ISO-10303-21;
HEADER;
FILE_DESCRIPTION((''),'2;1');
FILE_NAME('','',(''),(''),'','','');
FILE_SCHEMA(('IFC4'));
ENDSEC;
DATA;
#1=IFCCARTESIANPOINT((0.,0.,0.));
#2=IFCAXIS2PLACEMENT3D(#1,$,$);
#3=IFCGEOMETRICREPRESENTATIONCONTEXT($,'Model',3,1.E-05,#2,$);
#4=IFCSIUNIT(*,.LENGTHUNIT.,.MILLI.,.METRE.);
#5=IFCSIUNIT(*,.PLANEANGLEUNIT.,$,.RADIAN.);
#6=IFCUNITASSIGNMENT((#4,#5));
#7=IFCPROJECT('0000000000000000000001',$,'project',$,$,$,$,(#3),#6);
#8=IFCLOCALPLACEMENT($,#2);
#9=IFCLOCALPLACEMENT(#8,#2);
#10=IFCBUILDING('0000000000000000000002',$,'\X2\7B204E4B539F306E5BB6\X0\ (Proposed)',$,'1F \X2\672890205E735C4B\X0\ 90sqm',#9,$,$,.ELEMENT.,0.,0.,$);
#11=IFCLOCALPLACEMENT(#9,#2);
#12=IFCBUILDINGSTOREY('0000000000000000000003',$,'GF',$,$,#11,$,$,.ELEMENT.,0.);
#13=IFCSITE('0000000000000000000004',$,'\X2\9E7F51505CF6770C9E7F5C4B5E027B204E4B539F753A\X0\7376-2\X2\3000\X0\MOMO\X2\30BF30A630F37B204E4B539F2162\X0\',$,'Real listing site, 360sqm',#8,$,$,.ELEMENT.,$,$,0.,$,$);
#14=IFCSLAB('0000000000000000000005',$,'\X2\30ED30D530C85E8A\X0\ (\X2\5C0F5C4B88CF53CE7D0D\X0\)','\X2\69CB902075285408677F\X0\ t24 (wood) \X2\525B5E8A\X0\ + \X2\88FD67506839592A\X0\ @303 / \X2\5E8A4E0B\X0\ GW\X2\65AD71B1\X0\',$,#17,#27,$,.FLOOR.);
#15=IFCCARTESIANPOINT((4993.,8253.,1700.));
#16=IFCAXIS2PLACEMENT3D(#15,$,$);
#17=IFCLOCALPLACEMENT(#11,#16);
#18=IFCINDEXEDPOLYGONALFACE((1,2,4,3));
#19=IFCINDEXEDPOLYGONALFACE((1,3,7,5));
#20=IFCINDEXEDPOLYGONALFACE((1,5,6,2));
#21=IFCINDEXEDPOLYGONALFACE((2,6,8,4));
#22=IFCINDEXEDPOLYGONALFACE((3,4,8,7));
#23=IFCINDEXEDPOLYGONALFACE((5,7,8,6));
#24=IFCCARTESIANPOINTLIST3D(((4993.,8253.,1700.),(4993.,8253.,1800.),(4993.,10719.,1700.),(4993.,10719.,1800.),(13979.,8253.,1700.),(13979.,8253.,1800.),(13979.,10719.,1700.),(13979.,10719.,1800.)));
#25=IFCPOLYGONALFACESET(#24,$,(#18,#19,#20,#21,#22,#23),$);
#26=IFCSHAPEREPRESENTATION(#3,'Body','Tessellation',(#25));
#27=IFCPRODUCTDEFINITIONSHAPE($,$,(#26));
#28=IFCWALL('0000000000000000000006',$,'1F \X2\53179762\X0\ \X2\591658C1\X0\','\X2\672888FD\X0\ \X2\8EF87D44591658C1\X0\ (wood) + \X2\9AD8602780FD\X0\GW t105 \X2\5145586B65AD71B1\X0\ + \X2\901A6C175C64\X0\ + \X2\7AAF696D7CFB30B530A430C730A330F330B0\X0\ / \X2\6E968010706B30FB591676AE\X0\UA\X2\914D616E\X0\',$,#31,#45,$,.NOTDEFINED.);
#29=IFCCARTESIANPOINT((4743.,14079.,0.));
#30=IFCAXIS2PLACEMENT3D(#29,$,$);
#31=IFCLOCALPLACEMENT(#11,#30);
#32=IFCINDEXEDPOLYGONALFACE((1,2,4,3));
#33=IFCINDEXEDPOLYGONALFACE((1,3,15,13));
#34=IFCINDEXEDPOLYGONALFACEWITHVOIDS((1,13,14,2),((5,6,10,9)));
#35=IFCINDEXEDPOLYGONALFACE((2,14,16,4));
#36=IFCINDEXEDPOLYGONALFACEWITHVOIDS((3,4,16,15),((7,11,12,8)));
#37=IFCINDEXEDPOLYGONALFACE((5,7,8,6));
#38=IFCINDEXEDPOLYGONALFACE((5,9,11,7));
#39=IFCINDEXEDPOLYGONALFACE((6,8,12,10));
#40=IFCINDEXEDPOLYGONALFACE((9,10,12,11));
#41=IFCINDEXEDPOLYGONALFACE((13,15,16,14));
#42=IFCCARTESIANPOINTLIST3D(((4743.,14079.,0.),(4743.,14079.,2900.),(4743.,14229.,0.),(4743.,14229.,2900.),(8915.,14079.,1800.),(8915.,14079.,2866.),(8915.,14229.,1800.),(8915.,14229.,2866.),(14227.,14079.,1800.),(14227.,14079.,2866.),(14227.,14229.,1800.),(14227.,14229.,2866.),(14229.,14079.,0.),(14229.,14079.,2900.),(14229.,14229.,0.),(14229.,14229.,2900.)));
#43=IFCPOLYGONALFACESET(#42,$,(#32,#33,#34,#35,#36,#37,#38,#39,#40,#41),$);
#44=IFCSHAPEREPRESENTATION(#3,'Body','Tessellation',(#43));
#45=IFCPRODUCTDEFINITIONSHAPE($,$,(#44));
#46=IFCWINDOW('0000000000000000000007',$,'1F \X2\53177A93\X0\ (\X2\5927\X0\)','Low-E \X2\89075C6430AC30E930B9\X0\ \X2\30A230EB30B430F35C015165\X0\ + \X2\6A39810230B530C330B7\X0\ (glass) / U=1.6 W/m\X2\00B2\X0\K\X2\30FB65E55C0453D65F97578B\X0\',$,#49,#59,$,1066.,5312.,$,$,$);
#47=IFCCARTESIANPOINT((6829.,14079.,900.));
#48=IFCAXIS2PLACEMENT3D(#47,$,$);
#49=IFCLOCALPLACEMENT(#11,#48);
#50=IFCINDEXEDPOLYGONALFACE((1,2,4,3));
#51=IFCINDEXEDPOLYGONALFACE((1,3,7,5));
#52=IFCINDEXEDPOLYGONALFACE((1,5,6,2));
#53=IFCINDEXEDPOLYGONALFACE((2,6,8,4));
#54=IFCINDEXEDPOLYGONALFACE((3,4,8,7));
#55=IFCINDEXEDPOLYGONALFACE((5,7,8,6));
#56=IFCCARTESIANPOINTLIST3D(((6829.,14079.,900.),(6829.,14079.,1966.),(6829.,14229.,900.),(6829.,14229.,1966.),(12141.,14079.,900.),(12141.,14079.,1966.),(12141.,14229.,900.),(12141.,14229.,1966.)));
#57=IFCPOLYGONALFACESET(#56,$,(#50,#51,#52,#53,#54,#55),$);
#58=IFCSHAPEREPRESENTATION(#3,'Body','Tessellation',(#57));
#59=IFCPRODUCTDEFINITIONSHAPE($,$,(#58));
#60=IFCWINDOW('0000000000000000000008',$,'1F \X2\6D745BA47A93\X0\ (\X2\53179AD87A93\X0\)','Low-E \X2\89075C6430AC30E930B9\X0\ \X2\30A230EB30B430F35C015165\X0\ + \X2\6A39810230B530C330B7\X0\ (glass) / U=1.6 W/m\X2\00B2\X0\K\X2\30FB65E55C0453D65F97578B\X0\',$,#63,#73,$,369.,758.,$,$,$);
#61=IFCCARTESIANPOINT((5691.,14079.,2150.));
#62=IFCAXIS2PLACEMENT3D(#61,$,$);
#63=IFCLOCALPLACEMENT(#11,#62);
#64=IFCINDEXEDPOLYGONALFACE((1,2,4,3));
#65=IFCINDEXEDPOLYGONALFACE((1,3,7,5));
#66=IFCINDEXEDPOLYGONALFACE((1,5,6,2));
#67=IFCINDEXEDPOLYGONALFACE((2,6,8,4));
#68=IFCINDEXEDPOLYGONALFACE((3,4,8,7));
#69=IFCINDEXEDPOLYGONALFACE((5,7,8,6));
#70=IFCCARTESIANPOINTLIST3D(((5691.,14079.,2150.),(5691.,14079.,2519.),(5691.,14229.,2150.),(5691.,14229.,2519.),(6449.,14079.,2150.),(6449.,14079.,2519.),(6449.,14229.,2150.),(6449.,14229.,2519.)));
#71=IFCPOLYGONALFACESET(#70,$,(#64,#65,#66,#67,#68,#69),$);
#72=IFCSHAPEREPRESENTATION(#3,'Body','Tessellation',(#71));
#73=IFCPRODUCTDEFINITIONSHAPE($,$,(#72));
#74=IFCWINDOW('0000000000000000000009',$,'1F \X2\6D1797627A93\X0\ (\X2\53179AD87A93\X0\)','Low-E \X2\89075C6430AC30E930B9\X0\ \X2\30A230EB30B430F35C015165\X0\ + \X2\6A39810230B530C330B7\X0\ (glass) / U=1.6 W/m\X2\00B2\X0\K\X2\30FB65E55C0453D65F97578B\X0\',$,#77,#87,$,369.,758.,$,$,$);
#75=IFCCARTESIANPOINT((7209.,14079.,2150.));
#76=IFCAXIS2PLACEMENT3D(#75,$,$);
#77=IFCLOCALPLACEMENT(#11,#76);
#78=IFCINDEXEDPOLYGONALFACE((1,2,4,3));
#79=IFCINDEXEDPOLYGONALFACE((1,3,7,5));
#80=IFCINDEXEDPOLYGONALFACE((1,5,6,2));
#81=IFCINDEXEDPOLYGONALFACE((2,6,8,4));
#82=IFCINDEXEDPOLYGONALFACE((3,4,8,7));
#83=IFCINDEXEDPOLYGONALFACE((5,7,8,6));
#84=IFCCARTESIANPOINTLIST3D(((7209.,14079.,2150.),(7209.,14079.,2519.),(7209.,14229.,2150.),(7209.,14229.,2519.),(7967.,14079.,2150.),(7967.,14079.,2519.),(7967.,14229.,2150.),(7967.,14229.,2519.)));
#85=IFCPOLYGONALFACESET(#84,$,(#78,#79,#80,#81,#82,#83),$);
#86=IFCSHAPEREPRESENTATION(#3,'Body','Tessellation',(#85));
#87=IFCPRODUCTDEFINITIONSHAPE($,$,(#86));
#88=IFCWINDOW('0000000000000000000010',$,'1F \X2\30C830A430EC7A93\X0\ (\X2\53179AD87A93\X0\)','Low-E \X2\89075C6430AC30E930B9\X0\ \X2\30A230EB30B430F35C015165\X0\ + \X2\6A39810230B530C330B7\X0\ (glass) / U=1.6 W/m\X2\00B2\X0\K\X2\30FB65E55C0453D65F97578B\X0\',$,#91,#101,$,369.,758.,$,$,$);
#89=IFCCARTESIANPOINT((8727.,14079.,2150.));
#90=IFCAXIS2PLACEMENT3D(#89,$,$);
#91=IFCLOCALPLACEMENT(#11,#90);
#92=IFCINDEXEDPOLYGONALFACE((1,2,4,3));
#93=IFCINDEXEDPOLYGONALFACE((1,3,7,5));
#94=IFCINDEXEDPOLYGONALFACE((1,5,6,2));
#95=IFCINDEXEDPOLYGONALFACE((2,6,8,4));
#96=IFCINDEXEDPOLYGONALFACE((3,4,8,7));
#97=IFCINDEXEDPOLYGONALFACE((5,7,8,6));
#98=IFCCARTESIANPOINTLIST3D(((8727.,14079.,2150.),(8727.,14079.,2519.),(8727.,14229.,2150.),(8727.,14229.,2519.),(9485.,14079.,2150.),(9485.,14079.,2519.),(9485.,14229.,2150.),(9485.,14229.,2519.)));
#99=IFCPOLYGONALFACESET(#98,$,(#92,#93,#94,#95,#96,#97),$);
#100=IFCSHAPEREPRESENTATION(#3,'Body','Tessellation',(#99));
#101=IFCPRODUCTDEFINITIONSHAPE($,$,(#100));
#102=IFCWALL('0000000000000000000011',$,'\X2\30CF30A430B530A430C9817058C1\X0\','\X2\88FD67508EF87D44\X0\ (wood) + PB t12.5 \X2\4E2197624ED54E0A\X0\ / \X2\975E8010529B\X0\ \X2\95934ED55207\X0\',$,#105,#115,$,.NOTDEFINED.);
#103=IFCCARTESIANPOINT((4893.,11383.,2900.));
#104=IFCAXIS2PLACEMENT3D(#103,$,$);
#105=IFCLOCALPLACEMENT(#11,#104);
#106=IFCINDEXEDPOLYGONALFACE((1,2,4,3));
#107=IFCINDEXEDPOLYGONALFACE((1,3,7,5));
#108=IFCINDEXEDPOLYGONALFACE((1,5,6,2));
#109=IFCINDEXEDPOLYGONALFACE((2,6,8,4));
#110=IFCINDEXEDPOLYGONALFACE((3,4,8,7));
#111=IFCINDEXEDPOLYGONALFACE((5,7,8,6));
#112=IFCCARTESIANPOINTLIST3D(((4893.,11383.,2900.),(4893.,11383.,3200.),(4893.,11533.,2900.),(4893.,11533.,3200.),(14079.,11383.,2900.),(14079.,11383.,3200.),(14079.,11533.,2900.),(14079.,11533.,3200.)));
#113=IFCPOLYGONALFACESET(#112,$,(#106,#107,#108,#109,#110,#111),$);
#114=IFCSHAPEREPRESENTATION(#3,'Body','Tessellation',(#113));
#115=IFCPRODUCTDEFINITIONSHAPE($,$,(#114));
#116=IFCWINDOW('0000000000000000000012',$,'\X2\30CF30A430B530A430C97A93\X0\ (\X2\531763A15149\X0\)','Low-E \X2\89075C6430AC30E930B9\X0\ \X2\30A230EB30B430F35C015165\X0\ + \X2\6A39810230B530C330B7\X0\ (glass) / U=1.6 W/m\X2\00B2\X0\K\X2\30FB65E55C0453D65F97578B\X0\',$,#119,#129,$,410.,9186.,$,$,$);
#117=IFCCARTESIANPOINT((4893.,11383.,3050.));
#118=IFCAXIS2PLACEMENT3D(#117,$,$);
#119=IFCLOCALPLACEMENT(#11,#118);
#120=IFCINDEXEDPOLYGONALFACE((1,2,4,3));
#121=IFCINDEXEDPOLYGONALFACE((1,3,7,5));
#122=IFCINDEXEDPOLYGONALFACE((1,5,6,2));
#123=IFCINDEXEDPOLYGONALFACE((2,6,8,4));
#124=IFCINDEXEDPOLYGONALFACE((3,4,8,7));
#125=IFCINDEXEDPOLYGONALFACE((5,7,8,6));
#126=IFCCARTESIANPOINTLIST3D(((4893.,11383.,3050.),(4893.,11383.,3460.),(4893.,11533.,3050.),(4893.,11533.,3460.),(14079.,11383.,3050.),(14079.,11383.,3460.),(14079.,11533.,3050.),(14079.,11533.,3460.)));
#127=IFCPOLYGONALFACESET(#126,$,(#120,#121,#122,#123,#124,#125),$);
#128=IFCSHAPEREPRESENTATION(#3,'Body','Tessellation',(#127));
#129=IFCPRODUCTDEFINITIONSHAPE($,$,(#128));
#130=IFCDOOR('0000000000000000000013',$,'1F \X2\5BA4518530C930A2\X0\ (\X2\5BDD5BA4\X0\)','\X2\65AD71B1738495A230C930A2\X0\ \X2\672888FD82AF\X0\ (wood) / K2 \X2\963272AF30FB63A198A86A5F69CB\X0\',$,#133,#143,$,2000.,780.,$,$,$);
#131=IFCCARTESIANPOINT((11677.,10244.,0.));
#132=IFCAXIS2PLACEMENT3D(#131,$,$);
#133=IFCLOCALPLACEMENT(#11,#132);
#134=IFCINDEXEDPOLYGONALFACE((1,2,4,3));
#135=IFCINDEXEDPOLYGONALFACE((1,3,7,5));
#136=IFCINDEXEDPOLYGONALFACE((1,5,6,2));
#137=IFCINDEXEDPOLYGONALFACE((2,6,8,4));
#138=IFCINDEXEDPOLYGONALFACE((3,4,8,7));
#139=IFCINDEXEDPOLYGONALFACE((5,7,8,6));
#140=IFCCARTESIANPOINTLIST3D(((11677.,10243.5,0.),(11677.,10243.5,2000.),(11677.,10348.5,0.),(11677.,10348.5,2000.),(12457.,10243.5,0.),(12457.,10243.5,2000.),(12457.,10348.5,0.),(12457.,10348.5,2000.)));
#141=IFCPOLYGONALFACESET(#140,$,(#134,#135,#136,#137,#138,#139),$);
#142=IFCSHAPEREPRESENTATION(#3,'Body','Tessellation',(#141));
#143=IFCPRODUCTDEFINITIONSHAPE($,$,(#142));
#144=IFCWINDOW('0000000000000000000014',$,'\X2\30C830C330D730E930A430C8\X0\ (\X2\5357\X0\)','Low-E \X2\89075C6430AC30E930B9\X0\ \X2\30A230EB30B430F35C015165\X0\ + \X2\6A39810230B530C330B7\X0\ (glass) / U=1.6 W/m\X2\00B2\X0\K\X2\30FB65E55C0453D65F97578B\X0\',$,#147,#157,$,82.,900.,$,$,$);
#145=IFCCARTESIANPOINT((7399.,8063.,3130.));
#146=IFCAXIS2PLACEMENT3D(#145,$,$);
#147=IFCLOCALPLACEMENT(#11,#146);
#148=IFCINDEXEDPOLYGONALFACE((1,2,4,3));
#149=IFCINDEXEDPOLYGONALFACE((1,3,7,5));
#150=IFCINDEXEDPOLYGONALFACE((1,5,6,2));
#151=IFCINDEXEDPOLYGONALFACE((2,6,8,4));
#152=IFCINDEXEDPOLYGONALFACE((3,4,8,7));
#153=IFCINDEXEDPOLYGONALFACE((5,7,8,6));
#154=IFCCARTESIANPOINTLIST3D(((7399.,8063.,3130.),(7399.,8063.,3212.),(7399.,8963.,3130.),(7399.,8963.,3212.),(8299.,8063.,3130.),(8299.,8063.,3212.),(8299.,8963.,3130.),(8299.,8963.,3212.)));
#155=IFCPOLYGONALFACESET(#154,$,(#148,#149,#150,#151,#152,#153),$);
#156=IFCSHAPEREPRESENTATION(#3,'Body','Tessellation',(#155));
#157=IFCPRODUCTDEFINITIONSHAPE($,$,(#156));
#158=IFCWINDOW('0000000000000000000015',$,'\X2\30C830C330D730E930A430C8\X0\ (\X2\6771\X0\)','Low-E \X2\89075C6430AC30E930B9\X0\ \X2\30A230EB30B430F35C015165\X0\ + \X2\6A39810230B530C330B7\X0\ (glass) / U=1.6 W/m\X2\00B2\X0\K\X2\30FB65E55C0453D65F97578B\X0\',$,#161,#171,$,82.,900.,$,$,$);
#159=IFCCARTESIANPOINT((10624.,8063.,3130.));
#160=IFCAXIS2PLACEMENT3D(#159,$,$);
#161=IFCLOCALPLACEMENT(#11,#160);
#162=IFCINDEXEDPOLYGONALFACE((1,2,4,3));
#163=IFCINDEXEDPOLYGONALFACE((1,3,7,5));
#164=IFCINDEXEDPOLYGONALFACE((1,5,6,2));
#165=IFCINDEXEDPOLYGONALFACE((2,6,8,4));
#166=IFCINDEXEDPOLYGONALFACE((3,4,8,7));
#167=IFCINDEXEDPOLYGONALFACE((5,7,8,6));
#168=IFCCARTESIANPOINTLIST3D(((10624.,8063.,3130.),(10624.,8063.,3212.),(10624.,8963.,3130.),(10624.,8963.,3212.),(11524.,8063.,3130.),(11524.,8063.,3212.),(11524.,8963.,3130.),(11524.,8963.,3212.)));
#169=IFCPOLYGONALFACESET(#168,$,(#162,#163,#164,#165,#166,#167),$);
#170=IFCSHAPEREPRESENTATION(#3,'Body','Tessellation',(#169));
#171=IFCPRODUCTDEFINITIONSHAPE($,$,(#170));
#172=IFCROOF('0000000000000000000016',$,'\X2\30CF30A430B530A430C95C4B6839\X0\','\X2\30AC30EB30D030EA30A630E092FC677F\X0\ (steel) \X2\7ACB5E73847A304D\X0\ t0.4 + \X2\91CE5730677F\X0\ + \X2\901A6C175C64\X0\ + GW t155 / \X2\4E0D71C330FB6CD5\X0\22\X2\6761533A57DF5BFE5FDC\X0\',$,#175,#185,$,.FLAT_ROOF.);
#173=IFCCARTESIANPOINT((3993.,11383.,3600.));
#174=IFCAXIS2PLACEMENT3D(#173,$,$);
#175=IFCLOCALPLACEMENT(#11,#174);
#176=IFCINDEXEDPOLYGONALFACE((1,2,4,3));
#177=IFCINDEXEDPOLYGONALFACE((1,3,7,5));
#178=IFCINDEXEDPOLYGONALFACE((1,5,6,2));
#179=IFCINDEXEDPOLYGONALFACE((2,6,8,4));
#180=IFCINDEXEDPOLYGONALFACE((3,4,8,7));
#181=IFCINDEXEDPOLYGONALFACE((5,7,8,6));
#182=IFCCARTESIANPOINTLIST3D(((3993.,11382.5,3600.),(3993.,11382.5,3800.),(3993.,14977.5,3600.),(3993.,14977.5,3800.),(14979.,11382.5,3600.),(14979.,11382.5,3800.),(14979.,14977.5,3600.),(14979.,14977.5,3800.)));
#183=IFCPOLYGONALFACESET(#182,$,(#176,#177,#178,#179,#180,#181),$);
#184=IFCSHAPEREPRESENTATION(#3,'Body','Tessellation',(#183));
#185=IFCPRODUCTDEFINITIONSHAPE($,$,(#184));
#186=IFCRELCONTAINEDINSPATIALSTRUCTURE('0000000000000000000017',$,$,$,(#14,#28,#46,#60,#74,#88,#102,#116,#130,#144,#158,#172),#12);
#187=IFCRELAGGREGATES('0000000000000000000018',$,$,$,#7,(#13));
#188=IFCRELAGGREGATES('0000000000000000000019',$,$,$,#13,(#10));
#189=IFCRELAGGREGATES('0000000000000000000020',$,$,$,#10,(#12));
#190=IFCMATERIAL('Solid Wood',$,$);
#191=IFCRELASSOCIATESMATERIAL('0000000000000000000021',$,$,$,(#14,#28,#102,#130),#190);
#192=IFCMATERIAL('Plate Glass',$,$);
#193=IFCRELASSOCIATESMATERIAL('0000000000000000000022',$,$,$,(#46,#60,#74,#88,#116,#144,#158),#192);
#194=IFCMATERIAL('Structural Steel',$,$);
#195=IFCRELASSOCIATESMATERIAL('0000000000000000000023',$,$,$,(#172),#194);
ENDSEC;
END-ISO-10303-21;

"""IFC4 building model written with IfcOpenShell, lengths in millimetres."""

from ifc_helpers import new_model, si_unit, frame, frame_2d, origin, place, context, project, spatial, rectangle, extrude, material, element, fill, save


model = new_model("IFC4")

# Units and contexts
model_context = context("Model", 3, precision=1e-05, world=origin())
ifc_project = project(units=[si_unit("LENGTHUNIT", "METRE", prefix="MILLI"), si_unit("PLANEANGLEUNIT", "RADIAN")], contexts=[model_context])

# Site, building, storey
site_placement = place(None, origin())
site = spatial("IfcSite", under=ifc_project, at=site_placement, Name="鹿児島県鹿屋市笠之原町7376-2　MOMOタウン笠之原Ⅲ", ObjectType="Real listing site, 360sqm", CompositionType="ELEMENT", RefElevation=0.0)
building_placement = place(site_placement, origin())
building = spatial("IfcBuilding", under=site, at=building_placement, Name="笠之原の家 (Proposed)", ObjectType="1F 木造平屋 90sqm", CompositionType="ELEMENT", ElevationOfRefHeight=0.0, ElevationOfTerrain=0.0)
storey_placement = place(building_placement, origin())
storey = spatial("IfcBuildingStorey", under=building, at=storey_placement, Name="GF", CompositionType="ELEMENT", Elevation=0.0)

# Slab
ifc_material_1 = material(Name="Solid Wood")
slab_placement = place(storey_placement, frame((4993.0, 8253.0, 1700.0)))
element("IfcSlab", 1, at=slab_placement, inside=storey, material=ifc_material_1, Name="ロフト床 (小屋裏収納)", Description="構造用合板 t24 (wood) 剛床 + 製材根太 @303 / 床下 GW断熱", PredefinedType="FLOOR", context=model_context, shape_type="SweptSolid", body=[
    extrude(rectangle(XDim=8986.0, YDim=2466.0, at=frame_2d((4493.0, 1233.0))), frame((4993.0, 8253.0, 1700.0)), (0.0, 0.0, 1.0), 100.0),
])

# Wall, openings, windows
wall_1_placement = place(storey_placement, frame((4743.0, 14079.0, 0.0)))
wall_1 = element("IfcWall", 2, at=wall_1_placement, inside=storey, material=ifc_material_1, Name="1F 北面 外壁", Description="木製 軸組外壁 (wood) + 高性能GW t105 充填断熱 + 通気層 + 窯業系サイディング / 準耐火・外皮UA配慮", PredefinedType="NOTDEFINED", context=model_context, shape_type="SweptSolid", body=[
    extrude(rectangle(XDim=9486.0, YDim=150.0, at=frame_2d((4743.0, 75.0))), frame((4743.0, 14079.0, 0.0)), (0.0, 0.0, 1.0), 2900.0),
])
opening_1_placement = place(storey_placement, frame((6829.0, 14079.0, 900.0)))
opening_1 = element("IfcOpeningElement", 3, at=opening_1_placement, cuts=wall_1, PredefinedType="NOTDEFINED", context=model_context, shape_type="SweptSolid", body=[
    extrude(rectangle(XDim=5312.0, YDim=150.0, at=frame_2d((2656.0, 75.0))), frame((6829.0, 14079.0, 900.0)), (0.0, 0.0, 1.0), 1066.0),
])
opening_2_placement = place(storey_placement, frame((5691.0, 14079.0, 2150.0)))
opening_2 = element("IfcOpeningElement", 4, at=opening_2_placement, cuts=wall_1, PredefinedType="NOTDEFINED", context=model_context, shape_type="SweptSolid", body=[
    extrude(rectangle(XDim=758.0, YDim=150.0, at=frame_2d((379.0, 75.0))), frame((5691.0, 14079.0, 2150.0)), (0.0, 0.0, 1.0), 369.0),
])
opening_3_placement = place(storey_placement, frame((7209.0, 14079.0, 2150.0)))
opening_3 = element("IfcOpeningElement", 5, at=opening_3_placement, cuts=wall_1, PredefinedType="NOTDEFINED", context=model_context, shape_type="SweptSolid", body=[
    extrude(rectangle(XDim=758.0, YDim=150.0, at=frame_2d((379.0, 75.0))), frame((7209.0, 14079.0, 2150.0)), (0.0, 0.0, 1.0), 369.0),
])
opening_4_placement = place(storey_placement, frame((8727.0, 14079.0, 2150.0)))
opening_4 = element("IfcOpeningElement", 6, at=opening_4_placement, cuts=wall_1, PredefinedType="NOTDEFINED", context=model_context, shape_type="SweptSolid", body=[
    extrude(rectangle(XDim=758.0, YDim=150.0, at=frame_2d((379.0, 75.0))), frame((8727.0, 14079.0, 2150.0)), (0.0, 0.0, 1.0), 369.0),
])
ifc_material_2 = material(Name="Plate Glass")
window_1_placement = place(storey_placement, frame((6829.0, 14079.0, 900.0)))
window_1 = element("IfcWindow", 7, at=window_1_placement, inside=storey, material=ifc_material_2, Name="1F 北窓 (大)", Description="Low-E 複層ガラス アルゴン封入 + 樹脂サッシ (glass) / U=1.6 W/m²K・日射取得型", OverallHeight=1066.0, OverallWidth=5312.0, context=model_context, shape_type="SweptSolid", body=[
    extrude(rectangle(XDim=5312.0, YDim=150.0, at=frame_2d((2656.0, 75.0))), frame((6829.0, 14079.0, 900.0)), (0.0, 0.0, 1.0), 1066.0),
])
fill(opening_1, window_1)
window_2_placement = place(storey_placement, frame((5691.0, 14079.0, 2150.0)))
window_2 = element("IfcWindow", 8, at=window_2_placement, inside=storey, material=ifc_material_2, Name="1F 浴室窓 (北高窓)", Description="Low-E 複層ガラス アルゴン封入 + 樹脂サッシ (glass) / U=1.6 W/m²K・日射取得型", OverallHeight=369.0, OverallWidth=758.0, context=model_context, shape_type="SweptSolid", body=[
    extrude(rectangle(XDim=758.0, YDim=150.0, at=frame_2d((379.0, 75.0))), frame((5691.0, 14079.0, 2150.0)), (0.0, 0.0, 1.0), 369.0),
])
fill(opening_2, window_2)
window_3_placement = place(storey_placement, frame((7209.0, 14079.0, 2150.0)))
window_3 = element("IfcWindow", 9, at=window_3_placement, inside=storey, material=ifc_material_2, Name="1F 洗面窓 (北高窓)", Description="Low-E 複層ガラス アルゴン封入 + 樹脂サッシ (glass) / U=1.6 W/m²K・日射取得型", OverallHeight=369.0, OverallWidth=758.0, context=model_context, shape_type="SweptSolid", body=[
    extrude(rectangle(XDim=758.0, YDim=150.0, at=frame_2d((379.0, 75.0))), frame((7209.0, 14079.0, 2150.0)), (0.0, 0.0, 1.0), 369.0),
])
fill(opening_3, window_3)
window_4_placement = place(storey_placement, frame((8727.0, 14079.0, 2150.0)))
window_4 = element("IfcWindow", 10, at=window_4_placement, inside=storey, material=ifc_material_2, Name="1F トイレ窓 (北高窓)", Description="Low-E 複層ガラス アルゴン封入 + 樹脂サッシ (glass) / U=1.6 W/m²K・日射取得型", OverallHeight=369.0, OverallWidth=758.0, context=model_context, shape_type="SweptSolid", body=[
    extrude(rectangle(XDim=758.0, YDim=150.0, at=frame_2d((379.0, 75.0))), frame((8727.0, 14079.0, 2150.0)), (0.0, 0.0, 1.0), 369.0),
])
fill(opening_4, window_4)

# Wall, opening, window
wall_2_placement = place(storey_placement, frame((4893.0, 11383.0, 2900.0)))
wall_2 = element("IfcWall", 11, at=wall_2_placement, inside=storey, material=ifc_material_1, Name="ハイサイド腰壁", Description="製材軸組 (wood) + PB t12.5 両面仕上 / 非耐力 間仕切", PredefinedType="NOTDEFINED", context=model_context, shape_type="SweptSolid", body=[
    extrude(rectangle(XDim=9186.0, YDim=150.0, at=frame_2d((4593.0, 75.0))), frame((4893.0, 11383.0, 2900.0)), (0.0, 0.0, 1.0), 700.0),
])
opening_5_placement = place(storey_placement, frame((4893.0, 11383.0, 3050.0)))
opening_5 = element("IfcOpeningElement", 12, at=opening_5_placement, cuts=wall_2, PredefinedType="NOTDEFINED", context=model_context, shape_type="SweptSolid", body=[
    extrude(rectangle(XDim=9186.0, YDim=150.0, at=frame_2d((4593.0, 75.0))), frame((4893.0, 11383.0, 3050.0)), (0.0, 0.0, 1.0), 410.0),
])
window_5_placement = place(storey_placement, frame((4893.0, 11383.0, 3050.0)))
window_5 = element("IfcWindow", 13, at=window_5_placement, inside=storey, material=ifc_material_2, Name="ハイサイド窓 (北採光)", Description="Low-E 複層ガラス アルゴン封入 + 樹脂サッシ (glass) / U=1.6 W/m²K・日射取得型", OverallHeight=410.0, OverallWidth=9186.0, context=model_context, shape_type="SweptSolid", body=[
    extrude(rectangle(XDim=9186.0, YDim=150.0, at=frame_2d((4593.0, 75.0))), frame((4893.0, 11383.0, 3050.0)), (0.0, 0.0, 1.0), 410.0),
])
fill(opening_5, window_5)

# Door
door_1_placement = place(storey_placement, frame((11677.0, 10244.0, 0.0)))
element("IfcDoor", 14, at=door_1_placement, inside=storey, material=ifc_material_1, Name="1F 室内ドア (寝室)", Description="断熱玄関ドア 木製芯 (wood) / K2 防犯・採風機構", OverallHeight=2000.0, OverallWidth=780.0, context=model_context, shape_type="SweptSolid", body=[
    extrude(rectangle(XDim=780.0, YDim=105.0, at=frame_2d((390.0, 52.0))), frame((11677.0, 10244.0, 0.0)), (0.0, 0.0, 1.0), 2000.0),
])

# Windows
window_6_placement = place(storey_placement, frame((7399.0, 8063.0, 3130.0)))
element("IfcWindow", 15, at=window_6_placement, inside=storey, material=ifc_material_2, Name="トップライト (南)", Description="Low-E 複層ガラス アルゴン封入 + 樹脂サッシ (glass) / U=1.6 W/m²K・日射取得型", OverallHeight=82.0, OverallWidth=900.0, context=model_context, shape_type="SweptSolid", body=[
    extrude(rectangle(XDim=900.0, YDim=900.0, at=frame_2d((450.0, 450.0))), frame((7399.0, 8063.0, 3130.0)), (0.0, 0.0, 1.0), 82.0),
])
window_7_placement = place(storey_placement, frame((10624.0, 8063.0, 3130.0)))
element("IfcWindow", 16, at=window_7_placement, inside=storey, material=ifc_material_2, Name="トップライト (東)", Description="Low-E 複層ガラス アルゴン封入 + 樹脂サッシ (glass) / U=1.6 W/m²K・日射取得型", OverallHeight=82.0, OverallWidth=900.0, context=model_context, shape_type="SweptSolid", body=[
    extrude(rectangle(XDim=900.0, YDim=900.0, at=frame_2d((450.0, 450.0))), frame((10624.0, 8063.0, 3130.0)), (0.0, 0.0, 1.0), 82.0),
])

# Roof
ifc_material_3 = material(Name="Structural Steel")
roof_placement = place(storey_placement, frame((3993.0, 11383.0, 3600.0)))
element("IfcRoof", 17, at=roof_placement, inside=storey, material=ifc_material_3, Name="ハイサイド屋根", Description="ガルバリウム鋼板 (steel) 立平葺き t0.4 + 野地板 + 通気層 + GW t155 / 不燃・法22条区域対応", PredefinedType="FLAT_ROOF", context=model_context, shape_type="SweptSolid", body=[
    extrude(rectangle(XDim=10986.0, YDim=3595.0, at=frame_2d((5493.0, 1797.0))), frame((3993.0, 11383.0, 3600.0)), (0.0, 0.0, 1.0), 200.0),
])

save(model, "model.ifc")
